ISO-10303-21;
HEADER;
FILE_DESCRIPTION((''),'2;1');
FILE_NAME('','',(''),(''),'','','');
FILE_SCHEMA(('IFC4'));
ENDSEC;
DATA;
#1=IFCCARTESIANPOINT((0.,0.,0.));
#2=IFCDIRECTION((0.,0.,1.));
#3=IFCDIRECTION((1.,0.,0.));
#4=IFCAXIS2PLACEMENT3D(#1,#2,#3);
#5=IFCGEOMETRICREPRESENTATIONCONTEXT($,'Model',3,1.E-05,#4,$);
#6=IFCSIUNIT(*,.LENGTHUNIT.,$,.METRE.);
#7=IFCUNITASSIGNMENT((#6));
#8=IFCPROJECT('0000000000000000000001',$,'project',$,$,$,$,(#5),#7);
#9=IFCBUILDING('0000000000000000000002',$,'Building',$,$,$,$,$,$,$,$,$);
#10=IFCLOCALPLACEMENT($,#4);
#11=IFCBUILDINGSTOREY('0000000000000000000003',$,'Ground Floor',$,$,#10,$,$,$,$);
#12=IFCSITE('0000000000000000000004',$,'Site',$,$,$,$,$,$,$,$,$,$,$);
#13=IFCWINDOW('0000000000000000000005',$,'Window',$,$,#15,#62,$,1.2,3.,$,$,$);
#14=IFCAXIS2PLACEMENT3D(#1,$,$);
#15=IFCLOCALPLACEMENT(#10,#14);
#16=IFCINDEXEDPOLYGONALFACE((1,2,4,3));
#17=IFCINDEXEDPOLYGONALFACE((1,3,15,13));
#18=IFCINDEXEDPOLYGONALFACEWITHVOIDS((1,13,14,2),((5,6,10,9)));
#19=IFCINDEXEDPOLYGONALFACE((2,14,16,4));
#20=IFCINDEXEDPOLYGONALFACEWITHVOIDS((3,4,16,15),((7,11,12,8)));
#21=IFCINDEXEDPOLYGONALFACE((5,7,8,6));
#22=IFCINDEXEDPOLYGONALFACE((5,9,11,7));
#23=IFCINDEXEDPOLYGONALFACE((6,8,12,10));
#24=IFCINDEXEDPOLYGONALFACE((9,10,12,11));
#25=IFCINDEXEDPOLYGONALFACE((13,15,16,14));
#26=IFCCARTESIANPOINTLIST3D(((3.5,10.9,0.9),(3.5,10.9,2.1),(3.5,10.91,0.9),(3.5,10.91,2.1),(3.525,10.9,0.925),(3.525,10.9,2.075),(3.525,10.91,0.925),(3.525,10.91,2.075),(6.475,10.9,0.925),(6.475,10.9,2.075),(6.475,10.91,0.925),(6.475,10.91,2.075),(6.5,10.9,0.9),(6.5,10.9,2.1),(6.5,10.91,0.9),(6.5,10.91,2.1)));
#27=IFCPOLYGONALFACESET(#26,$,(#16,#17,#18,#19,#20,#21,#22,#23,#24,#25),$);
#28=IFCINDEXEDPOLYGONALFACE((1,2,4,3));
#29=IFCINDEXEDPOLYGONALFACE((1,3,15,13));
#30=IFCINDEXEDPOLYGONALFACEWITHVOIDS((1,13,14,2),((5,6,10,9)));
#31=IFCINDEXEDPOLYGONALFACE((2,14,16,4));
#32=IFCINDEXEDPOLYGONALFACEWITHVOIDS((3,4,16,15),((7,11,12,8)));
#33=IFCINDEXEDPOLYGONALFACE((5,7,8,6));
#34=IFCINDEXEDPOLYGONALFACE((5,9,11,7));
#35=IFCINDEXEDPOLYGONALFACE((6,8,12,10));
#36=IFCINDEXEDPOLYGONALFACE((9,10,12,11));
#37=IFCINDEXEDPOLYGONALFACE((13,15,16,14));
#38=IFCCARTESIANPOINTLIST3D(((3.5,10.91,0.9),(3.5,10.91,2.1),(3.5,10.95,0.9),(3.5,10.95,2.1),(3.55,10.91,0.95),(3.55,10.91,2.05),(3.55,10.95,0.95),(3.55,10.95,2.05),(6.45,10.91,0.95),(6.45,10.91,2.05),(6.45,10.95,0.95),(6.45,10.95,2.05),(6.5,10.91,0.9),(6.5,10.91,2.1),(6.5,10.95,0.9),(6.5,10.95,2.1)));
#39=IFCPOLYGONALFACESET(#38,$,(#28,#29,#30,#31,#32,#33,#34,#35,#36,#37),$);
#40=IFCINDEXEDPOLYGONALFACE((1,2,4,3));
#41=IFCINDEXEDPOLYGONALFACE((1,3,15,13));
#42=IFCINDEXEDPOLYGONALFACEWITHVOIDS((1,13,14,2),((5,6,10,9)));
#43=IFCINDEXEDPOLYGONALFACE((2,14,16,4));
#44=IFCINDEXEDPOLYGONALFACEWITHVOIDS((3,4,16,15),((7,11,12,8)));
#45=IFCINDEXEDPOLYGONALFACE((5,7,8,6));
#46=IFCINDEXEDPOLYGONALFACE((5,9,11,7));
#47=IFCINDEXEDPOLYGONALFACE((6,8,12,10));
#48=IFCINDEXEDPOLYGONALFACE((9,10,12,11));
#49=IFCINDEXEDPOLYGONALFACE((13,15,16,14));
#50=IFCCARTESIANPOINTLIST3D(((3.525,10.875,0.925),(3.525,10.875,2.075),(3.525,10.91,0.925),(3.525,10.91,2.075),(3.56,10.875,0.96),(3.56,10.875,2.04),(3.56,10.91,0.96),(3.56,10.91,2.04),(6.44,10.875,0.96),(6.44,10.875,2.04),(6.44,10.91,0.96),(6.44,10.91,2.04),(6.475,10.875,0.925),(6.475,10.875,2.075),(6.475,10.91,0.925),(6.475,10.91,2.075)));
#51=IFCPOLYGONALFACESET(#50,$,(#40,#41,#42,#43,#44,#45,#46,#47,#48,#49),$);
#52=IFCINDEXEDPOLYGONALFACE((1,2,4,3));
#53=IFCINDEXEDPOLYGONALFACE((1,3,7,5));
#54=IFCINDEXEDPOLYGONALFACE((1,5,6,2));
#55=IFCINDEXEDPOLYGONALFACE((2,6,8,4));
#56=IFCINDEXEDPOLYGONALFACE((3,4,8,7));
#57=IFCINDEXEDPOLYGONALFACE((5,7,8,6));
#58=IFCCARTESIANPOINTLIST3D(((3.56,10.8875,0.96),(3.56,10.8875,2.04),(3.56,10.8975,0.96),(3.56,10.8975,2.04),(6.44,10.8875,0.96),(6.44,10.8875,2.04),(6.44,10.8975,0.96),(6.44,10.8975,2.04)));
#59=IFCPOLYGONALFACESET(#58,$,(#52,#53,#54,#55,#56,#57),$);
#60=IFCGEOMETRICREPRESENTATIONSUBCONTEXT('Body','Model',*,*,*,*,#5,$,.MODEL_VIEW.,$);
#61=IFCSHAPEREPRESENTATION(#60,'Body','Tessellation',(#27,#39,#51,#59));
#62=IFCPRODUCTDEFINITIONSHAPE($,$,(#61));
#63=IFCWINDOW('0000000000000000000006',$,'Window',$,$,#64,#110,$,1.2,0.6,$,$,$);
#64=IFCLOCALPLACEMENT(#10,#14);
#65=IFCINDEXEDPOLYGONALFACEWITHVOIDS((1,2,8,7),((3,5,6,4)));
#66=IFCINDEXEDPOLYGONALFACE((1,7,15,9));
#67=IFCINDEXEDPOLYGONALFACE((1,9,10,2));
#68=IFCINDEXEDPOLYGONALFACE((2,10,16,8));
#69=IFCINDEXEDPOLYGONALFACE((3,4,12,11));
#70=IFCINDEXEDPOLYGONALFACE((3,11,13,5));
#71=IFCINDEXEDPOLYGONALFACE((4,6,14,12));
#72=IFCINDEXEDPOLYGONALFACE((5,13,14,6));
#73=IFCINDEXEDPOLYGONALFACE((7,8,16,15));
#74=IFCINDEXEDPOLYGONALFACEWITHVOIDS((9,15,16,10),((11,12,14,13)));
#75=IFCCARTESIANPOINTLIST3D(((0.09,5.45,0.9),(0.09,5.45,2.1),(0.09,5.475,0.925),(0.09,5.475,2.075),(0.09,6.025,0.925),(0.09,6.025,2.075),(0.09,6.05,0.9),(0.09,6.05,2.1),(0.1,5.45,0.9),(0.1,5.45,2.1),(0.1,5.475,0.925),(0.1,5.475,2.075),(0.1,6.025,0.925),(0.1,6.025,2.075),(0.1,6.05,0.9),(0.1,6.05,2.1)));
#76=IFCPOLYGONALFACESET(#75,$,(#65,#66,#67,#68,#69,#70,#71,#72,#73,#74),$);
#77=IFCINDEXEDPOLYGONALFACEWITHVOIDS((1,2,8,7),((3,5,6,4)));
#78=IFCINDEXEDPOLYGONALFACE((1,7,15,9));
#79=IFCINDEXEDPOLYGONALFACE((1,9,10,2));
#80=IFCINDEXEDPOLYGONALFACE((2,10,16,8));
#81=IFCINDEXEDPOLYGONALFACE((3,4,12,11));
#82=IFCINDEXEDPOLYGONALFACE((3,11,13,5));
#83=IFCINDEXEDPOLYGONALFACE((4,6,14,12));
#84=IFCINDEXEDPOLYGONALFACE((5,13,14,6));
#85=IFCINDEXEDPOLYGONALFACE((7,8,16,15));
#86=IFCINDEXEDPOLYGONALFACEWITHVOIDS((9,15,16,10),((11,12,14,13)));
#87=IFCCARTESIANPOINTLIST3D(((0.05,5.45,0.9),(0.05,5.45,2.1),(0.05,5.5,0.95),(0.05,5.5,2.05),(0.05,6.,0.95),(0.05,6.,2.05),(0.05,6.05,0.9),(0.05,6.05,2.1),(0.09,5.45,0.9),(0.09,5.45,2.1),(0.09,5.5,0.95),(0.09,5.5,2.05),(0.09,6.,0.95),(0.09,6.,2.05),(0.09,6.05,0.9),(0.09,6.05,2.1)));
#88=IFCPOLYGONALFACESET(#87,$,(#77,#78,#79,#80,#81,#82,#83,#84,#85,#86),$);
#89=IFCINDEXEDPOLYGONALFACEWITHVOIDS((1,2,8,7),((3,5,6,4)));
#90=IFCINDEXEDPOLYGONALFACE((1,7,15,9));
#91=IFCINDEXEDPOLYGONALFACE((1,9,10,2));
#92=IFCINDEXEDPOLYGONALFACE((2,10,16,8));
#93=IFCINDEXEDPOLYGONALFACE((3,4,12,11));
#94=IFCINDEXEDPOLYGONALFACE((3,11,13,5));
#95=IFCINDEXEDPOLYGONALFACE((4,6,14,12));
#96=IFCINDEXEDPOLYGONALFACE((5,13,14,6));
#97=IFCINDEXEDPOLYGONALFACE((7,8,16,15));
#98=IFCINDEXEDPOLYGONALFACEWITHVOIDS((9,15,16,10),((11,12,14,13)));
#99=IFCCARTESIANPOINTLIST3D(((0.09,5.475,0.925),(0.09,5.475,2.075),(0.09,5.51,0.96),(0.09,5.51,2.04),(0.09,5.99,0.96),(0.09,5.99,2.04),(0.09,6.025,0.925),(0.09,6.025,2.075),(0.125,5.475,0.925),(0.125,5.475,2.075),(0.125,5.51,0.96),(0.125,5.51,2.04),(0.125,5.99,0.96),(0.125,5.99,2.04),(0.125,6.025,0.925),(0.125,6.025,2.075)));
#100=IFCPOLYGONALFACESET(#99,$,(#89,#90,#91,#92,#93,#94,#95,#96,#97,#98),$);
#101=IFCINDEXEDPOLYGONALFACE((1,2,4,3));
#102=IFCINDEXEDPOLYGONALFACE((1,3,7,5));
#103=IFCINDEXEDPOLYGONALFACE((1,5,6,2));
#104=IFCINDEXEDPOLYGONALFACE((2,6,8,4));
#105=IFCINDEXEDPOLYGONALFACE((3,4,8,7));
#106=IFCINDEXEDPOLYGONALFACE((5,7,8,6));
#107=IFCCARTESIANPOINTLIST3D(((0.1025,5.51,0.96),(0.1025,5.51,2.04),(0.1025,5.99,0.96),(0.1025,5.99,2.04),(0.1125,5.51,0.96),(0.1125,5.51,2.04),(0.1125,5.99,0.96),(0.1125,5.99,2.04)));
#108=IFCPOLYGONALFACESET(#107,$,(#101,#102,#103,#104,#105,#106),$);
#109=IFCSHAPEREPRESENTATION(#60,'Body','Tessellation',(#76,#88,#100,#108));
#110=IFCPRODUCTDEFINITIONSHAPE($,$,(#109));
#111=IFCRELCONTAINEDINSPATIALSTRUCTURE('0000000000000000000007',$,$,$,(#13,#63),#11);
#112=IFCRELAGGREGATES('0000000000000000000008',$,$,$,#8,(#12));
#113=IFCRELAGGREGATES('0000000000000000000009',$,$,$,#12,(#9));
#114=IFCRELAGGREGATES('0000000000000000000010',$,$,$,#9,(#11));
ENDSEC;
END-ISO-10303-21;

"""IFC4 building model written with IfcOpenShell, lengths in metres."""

from ifc_helpers import new_model, si_unit, frame, origin_with_axes, place, context, subcontext, project, spatial, line, indexed_curve, outline, extrude, element, save


model = new_model("IFC4")

# Units and contexts
model_context = context("Model", 3, precision=1e-05, world=origin_with_axes())
body_context = subcontext(model_context, "Body", "Model", "MODEL_VIEW")
ifc_project = project(units=[si_unit("LENGTHUNIT", "METRE")], contexts=[model_context])

# Site, building, storey
site = spatial("IfcSite", under=ifc_project, Name="Site")
building = spatial("IfcBuilding", under=site, Name="Building")
storey_placement = place(None, origin_with_axes())
storey = spatial("IfcBuildingStorey", under=building, at=storey_placement, Name="Ground Floor")

# Windows
window_1_placement = place(storey_placement, frame((6.5, 11.0, 0.9), z_axis=(0.0, 0.0, 1.0), x_axis=(-1.0, 0.0, 0.0)))
element("IfcWindow", 1, at=window_1_placement, inside=storey, Name="Window", OverallHeight=1.2, OverallWidth=3.0, context=body_context, shape_type="SweptSolid", body=[
    extrude(outline(indexed_curve([(0.0, 0.0), (3.0, 0.0), (3.0, 1.2), (0.0, 1.2)], segments=[line(1, 2, 3, 4, 1)]), holes=[indexed_curve([(0.025, 0.025), (2.975, 0.025), (2.975, 1.175), (0.025, 1.175)], segments=[line(1, 2, 3, 4, 1)])]), frame((0.0, 0.09, 0.0), z_axis=(0.0, -1.0, 0.0), x_axis=(1.0, 0.0, 0.0)), (0.0, 0.0, -1.0), 0.01),
    extrude(outline(indexed_curve([(0.0, 0.0), (3.0, 0.0), (3.0, 1.2), (0.0, 1.2)], segments=[line(1, 2, 3, 4, 1)]), holes=[indexed_curve([(0.05, 0.05), (2.95, 0.05), (2.95, 1.15), (0.05, 1.15)], segments=[line(1, 2, 3, 4, 1)])]), frame((0.0, 0.05, 0.0), z_axis=(0.0, -1.0, 0.0), x_axis=(1.0, 0.0, 0.0)), (0.0, 0.0, -1.0), 0.04),
    extrude(outline(indexed_curve([(0.0, 0.0), (2.95, 0.0), (2.95, 1.15), (0.0, 1.15)], segments=[line(1, 2, 3, 4, 1)]), holes=[indexed_curve([(0.035, 0.035), (2.915, 0.035), (2.915, 1.115), (0.035, 1.115)], segments=[line(1, 2, 3, 4, 1)])]), frame((0.025, 0.09, 0.025), z_axis=(0.0, -1.0, 0.0), x_axis=(1.0, 0.0, 0.0)), (0.0, 0.0, -1.0), 0.035),
    extrude(outline(indexed_curve([(0.035, 0.035), (2.915, 0.035), (2.915, 1.115), (0.035, 1.115)], segments=[line(1, 2, 3, 4, 1)])), frame((0.025, 0.1025, 0.025), z_axis=(0.0, -1.0, 0.0), x_axis=(1.0, 0.0, 0.0)), (0.0, 0.0, -1.0), 0.01),
])
window_2_placement = place(storey_placement, frame((0.0, 6.05, 0.9), z_axis=(0.0, 0.0, 1.0), x_axis=(0.0, -1.0, 0.0)))
element("IfcWindow", 2, at=window_2_placement, inside=storey, Name="Window", OverallHeight=1.2, OverallWidth=0.6, context=body_context, shape_type="SweptSolid", body=[
    extrude(outline(indexed_curve([(0.0, 0.0), (0.6, 0.0), (0.6, 1.2), (0.0, 1.2)], segments=[line(1, 2, 3, 4, 1)]), holes=[indexed_curve([(0.025, 0.025), (0.575, 0.025), (0.575, 1.175), (0.025, 1.175)], segments=[line(1, 2, 3, 4, 1)])]), frame((0.0, 0.09, 0.0), z_axis=(0.0, -1.0, 0.0), x_axis=(1.0, 0.0, 0.0)), (0.0, 0.0, -1.0), 0.01),
    extrude(outline(indexed_curve([(0.0, 0.0), (0.6, 0.0), (0.6, 1.2), (0.0, 1.2)], segments=[line(1, 2, 3, 4, 1)]), holes=[indexed_curve([(0.05, 0.05), (0.55, 0.05), (0.55, 1.15), (0.05, 1.15)], segments=[line(1, 2, 3, 4, 1)])]), frame((0.0, 0.05, 0.0), z_axis=(0.0, -1.0, 0.0), x_axis=(1.0, 0.0, 0.0)), (0.0, 0.0, -1.0), 0.04),
    extrude(outline(indexed_curve([(0.0, 0.0), (0.55, 0.0), (0.55, 1.15), (0.0, 1.15)], segments=[line(1, 2, 3, 4, 1)]), holes=[indexed_curve([(0.035, 0.035), (0.515, 0.035), (0.515, 1.115), (0.035, 1.115)], segments=[line(1, 2, 3, 4, 1)])]), frame((0.025, 0.09, 0.025), z_axis=(0.0, -1.0, 0.0), x_axis=(1.0, 0.0, 0.0)), (0.0, 0.0, -1.0), 0.035),
    extrude(outline(indexed_curve([(0.035, 0.035), (0.515, 0.035), (0.515, 1.115), (0.035, 1.115)], segments=[line(1, 2, 3, 4, 1)])), frame((0.025, 0.1025, 0.025), z_axis=(0.0, -1.0, 0.0), x_axis=(1.0, 0.0, 0.0)), (0.0, 0.0, -1.0), 0.01),
])

save(model, "model.ifc")
